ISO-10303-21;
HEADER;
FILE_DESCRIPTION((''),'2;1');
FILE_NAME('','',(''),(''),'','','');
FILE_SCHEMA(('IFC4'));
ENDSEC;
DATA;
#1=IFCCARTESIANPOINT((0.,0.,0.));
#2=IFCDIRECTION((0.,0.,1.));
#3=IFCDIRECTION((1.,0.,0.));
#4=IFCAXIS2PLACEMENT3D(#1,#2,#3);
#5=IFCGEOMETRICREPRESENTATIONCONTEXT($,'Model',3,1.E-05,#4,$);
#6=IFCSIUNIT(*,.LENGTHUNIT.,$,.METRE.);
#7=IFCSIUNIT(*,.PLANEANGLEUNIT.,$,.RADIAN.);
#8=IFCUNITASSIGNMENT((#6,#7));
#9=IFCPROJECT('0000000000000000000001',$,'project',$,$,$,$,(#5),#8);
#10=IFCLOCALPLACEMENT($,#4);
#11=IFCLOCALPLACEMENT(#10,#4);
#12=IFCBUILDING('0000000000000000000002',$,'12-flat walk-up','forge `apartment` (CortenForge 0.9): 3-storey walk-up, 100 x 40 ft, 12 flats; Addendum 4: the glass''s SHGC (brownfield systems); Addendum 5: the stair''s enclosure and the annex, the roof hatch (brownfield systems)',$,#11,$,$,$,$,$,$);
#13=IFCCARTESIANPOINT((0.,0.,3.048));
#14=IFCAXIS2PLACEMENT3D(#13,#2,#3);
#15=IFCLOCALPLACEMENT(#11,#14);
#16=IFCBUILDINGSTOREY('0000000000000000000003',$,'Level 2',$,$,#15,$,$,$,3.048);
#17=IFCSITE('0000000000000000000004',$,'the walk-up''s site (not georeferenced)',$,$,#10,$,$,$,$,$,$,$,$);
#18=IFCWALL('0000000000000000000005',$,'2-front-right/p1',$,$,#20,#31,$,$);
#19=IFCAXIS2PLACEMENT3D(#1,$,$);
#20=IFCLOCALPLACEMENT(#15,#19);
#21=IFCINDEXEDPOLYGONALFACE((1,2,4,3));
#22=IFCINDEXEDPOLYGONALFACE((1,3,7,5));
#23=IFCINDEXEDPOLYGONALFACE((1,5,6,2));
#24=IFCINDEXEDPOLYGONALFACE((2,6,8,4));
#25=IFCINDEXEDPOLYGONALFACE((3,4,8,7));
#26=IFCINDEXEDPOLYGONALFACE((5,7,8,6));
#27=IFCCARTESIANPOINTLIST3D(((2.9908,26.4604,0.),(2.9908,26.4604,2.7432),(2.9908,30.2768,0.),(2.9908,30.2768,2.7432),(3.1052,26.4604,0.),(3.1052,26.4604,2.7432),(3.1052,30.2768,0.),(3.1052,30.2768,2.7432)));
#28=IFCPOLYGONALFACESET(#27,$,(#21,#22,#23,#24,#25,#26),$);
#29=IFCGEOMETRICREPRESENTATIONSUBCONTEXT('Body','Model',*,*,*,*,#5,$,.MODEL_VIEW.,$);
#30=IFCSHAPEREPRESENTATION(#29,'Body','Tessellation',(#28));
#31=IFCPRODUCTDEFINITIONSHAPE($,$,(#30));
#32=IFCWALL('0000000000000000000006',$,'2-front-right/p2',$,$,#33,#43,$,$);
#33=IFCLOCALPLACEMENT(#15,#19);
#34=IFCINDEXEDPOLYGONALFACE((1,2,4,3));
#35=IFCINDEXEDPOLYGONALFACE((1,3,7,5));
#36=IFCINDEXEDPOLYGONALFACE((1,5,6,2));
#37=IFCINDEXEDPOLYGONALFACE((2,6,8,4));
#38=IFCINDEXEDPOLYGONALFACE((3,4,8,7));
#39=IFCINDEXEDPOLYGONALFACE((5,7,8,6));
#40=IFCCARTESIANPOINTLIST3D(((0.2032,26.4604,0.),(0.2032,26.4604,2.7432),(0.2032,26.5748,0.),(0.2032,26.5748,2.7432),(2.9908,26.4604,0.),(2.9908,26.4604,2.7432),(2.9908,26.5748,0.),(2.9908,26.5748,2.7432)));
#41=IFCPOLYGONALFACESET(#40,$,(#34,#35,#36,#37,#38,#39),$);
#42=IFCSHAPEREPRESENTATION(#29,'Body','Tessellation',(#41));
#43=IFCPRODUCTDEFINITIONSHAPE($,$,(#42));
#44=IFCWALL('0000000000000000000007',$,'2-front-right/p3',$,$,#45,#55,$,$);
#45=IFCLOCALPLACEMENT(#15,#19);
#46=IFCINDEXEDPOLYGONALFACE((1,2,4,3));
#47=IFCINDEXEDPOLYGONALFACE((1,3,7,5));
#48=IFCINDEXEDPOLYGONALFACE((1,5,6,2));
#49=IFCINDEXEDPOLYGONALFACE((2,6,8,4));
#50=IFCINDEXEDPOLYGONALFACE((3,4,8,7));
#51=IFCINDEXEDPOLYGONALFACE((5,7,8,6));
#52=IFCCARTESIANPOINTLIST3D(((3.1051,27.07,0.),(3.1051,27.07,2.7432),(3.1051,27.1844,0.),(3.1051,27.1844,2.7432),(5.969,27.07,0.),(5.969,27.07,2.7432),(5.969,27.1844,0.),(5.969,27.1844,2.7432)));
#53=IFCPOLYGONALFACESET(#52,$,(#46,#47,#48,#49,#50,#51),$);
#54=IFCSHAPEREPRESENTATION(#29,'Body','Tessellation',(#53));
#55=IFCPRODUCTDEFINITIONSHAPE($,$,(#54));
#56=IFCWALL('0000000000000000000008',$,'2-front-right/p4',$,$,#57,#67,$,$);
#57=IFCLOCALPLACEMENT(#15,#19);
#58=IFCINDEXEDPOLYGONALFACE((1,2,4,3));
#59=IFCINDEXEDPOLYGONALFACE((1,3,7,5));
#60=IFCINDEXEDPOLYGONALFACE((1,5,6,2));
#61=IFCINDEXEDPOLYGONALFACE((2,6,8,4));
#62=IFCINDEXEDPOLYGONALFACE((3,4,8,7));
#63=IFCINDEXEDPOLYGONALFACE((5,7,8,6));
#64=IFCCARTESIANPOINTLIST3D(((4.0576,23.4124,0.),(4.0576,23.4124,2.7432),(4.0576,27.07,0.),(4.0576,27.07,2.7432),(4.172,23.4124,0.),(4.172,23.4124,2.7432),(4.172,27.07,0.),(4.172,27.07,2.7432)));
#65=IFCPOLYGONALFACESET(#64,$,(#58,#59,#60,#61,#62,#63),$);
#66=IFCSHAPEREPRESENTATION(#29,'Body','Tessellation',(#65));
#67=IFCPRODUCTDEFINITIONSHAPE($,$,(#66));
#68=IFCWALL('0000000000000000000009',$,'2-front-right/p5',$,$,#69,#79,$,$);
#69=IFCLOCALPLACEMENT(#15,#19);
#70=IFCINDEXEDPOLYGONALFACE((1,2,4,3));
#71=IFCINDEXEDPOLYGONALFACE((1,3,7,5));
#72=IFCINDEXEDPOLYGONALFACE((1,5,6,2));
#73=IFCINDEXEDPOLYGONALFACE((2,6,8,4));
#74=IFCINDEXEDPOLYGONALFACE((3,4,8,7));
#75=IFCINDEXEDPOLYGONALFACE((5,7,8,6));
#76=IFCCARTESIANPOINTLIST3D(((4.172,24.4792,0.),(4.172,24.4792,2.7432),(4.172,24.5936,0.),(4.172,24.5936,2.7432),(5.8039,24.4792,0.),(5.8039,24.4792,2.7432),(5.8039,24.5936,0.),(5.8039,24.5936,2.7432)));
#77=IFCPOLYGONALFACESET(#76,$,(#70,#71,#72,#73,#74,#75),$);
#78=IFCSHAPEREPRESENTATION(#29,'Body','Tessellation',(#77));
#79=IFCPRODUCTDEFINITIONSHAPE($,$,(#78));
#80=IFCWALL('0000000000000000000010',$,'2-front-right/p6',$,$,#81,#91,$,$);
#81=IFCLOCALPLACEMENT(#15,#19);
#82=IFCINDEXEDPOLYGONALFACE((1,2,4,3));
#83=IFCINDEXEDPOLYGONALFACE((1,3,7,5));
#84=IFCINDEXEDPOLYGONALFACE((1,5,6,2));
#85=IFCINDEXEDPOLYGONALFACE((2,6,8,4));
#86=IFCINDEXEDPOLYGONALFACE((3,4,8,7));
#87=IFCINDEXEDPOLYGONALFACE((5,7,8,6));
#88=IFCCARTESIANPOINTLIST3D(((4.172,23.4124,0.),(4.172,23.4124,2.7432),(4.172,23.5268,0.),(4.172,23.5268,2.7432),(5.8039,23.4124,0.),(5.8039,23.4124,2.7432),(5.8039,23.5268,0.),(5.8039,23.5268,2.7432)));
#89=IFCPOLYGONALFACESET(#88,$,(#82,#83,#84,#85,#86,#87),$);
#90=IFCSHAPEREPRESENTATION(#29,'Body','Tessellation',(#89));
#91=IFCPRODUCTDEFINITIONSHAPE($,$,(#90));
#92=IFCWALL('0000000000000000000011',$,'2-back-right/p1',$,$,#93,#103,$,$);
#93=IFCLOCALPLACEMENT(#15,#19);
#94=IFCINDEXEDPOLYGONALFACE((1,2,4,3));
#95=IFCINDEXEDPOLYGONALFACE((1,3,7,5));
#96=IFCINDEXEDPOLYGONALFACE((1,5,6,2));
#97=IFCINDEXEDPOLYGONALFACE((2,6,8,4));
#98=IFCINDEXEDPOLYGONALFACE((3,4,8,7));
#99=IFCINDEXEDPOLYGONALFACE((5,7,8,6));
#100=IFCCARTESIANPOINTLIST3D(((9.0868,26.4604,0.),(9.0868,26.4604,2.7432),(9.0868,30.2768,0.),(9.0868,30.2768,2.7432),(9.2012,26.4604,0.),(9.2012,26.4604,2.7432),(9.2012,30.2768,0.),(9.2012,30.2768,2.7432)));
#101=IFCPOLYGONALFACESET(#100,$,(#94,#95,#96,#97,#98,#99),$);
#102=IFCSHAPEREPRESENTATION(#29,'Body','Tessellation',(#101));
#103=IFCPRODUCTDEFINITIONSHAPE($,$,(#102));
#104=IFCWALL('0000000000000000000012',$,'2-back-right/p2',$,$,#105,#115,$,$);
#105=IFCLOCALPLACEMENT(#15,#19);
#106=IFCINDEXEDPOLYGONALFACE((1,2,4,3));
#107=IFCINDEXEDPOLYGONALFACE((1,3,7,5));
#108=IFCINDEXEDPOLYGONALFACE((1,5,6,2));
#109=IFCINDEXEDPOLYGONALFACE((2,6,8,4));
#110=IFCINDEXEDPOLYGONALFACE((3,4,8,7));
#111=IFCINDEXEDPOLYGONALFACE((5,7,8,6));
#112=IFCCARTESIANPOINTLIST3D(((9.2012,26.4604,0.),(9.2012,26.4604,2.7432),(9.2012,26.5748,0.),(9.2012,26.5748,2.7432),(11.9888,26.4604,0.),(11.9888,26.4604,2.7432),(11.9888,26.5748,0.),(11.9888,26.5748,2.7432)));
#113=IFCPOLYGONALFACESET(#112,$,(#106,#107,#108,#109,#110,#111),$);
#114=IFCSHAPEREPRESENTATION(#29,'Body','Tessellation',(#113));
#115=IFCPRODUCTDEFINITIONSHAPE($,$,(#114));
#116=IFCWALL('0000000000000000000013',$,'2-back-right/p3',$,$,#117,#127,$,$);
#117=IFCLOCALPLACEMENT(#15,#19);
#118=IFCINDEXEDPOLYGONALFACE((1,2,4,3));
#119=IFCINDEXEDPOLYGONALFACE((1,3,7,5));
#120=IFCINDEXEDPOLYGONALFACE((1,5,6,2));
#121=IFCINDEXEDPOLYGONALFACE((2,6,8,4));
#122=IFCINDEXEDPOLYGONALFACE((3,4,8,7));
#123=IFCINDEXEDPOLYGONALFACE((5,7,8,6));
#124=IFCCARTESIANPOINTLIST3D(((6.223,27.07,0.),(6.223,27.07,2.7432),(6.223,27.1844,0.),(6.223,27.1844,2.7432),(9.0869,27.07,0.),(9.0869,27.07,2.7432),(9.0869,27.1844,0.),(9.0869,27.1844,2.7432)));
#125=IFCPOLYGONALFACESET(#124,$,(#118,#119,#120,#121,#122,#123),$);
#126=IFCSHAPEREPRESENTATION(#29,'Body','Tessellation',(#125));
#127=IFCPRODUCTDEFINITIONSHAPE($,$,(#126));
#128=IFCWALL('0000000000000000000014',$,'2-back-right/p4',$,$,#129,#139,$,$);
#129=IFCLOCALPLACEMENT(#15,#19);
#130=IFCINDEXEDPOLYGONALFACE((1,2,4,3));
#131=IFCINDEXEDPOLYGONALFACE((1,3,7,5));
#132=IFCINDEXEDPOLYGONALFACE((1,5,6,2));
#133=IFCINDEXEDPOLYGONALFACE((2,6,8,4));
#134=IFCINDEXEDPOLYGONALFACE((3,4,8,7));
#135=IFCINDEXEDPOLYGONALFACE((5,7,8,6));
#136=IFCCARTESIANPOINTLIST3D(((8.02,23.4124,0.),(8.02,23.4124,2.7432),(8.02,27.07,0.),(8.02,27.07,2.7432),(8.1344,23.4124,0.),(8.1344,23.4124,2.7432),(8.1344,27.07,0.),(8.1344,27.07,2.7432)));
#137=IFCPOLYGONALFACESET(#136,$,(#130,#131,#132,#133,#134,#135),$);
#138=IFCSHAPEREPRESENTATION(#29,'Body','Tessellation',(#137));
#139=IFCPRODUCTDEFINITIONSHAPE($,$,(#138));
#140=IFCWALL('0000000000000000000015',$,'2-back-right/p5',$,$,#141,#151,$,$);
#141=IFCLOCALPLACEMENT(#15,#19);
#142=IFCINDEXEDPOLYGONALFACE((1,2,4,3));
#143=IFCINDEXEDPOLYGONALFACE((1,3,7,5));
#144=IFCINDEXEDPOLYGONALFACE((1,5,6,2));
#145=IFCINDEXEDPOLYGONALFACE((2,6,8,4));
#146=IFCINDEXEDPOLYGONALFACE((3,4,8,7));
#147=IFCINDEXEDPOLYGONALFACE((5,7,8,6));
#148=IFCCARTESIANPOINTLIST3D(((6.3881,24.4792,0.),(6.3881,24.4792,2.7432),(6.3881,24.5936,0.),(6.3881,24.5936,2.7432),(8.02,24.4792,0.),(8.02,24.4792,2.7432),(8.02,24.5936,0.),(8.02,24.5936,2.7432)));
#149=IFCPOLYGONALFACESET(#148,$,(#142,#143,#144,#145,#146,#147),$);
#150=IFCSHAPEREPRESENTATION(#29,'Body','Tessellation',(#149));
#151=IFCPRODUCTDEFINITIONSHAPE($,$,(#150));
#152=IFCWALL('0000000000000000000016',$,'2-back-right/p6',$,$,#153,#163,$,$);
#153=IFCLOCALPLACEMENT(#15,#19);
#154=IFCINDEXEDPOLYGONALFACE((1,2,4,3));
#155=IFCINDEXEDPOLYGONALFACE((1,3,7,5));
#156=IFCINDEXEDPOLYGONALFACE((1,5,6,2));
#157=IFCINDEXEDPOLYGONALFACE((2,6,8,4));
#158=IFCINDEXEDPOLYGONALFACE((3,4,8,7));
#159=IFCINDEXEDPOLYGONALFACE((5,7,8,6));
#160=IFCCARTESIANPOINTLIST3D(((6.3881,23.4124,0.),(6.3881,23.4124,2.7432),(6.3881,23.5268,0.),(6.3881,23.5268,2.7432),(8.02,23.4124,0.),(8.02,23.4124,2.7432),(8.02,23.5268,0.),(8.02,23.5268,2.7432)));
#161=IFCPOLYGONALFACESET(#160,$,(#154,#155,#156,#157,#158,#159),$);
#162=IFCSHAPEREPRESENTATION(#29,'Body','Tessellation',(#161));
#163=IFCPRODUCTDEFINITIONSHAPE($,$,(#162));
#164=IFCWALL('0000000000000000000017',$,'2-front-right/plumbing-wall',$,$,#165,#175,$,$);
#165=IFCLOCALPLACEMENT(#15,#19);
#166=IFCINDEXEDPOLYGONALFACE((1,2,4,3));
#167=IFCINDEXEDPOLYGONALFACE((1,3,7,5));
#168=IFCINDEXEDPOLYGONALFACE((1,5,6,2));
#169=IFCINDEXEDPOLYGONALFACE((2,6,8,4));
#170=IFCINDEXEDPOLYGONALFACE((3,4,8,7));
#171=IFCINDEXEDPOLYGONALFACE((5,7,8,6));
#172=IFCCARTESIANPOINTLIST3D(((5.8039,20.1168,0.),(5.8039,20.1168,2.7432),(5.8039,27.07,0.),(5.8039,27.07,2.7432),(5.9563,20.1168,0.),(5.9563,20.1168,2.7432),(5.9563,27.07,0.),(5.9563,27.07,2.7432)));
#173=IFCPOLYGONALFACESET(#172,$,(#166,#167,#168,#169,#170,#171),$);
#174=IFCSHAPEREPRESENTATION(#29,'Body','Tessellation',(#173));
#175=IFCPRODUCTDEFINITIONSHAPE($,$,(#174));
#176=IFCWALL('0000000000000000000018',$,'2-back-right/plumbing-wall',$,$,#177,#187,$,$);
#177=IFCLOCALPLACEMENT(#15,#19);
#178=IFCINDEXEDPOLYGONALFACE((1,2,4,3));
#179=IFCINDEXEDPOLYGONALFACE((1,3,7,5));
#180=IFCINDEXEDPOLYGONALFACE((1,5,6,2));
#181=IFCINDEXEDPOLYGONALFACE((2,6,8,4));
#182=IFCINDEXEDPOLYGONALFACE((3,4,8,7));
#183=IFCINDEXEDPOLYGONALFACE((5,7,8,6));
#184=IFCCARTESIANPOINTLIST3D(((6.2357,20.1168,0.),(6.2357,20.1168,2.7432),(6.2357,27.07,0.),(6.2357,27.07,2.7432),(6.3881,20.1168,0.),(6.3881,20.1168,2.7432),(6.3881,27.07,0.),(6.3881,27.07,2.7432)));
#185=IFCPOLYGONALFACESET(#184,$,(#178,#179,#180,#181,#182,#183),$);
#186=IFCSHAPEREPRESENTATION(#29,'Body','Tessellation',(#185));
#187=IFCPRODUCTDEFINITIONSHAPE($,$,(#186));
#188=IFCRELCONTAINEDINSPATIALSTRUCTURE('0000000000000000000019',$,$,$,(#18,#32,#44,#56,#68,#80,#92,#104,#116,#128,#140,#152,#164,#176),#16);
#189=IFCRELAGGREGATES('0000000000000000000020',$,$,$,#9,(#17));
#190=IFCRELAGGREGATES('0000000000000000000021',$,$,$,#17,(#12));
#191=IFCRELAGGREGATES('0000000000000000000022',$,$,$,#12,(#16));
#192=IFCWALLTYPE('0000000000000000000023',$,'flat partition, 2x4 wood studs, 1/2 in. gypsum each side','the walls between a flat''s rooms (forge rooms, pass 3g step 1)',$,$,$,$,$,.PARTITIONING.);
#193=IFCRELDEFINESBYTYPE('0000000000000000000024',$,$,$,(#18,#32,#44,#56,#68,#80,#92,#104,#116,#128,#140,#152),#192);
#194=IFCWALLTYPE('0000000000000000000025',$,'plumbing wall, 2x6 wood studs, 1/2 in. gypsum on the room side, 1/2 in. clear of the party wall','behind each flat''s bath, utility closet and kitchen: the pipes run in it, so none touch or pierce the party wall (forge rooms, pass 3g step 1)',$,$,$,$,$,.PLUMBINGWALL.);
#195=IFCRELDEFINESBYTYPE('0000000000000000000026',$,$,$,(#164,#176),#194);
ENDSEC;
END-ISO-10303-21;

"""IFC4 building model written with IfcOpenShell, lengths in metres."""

from ifc_helpers import new_model, si_unit, frame, frame_2d, origin, origin_with_axes, place, context, subcontext, project, spatial, rectangle, extrude, type_object, element, save


model = new_model("IFC4")

# Units and contexts
model_context = context("Model", 3, precision=1e-05, world=origin_with_axes())
body_context = subcontext(model_context, "Body", "Model", "MODEL_VIEW")
ifc_project = project(units=[si_unit("LENGTHUNIT", "METRE"), si_unit("PLANEANGLEUNIT", "RADIAN")], contexts=[model_context])

# Site, building, storey
site_placement = place(None, origin_with_axes())
site = spatial("IfcSite", under=ifc_project, at=site_placement, Name="the walk-up's site (not georeferenced)")
building_placement = place(site_placement, origin_with_axes())
building = spatial("IfcBuilding", under=site, at=building_placement, Name="12-flat walk-up", Description="forge `apartment` (CortenForge 0.9): 3-storey walk-up, 100 x 40 ft, 12 flats; Addendum 4: the glass's SHGC (brownfield systems); Addendum 5: the stair's enclosure and the annex, the roof hatch (brownfield systems)")
storey_placement = place(building_placement, frame((0.0, 0.0, 3.048), z_axis=(0.0, 0.0, 1.0), x_axis=(1.0, 0.0, 0.0)))
storey = spatial("IfcBuildingStorey", under=building, at=storey_placement, Name="Level 2", Elevation=3.048)

# Walls
wall_type_1 = type_object("IfcWallType", Name="flat partition, 2x4 wood studs, 1/2 in. gypsum each side", Description="the walls between a flat's rooms (forge rooms, pass 3g step 1)", PredefinedType="PARTITIONING")
wall_1_placement = place(storey_placement, frame((2.9909, 26.4605, 0.0), z_axis=(0.0, 0.0, 1.0), x_axis=(1.0, 0.0, 0.0)))
element("IfcWall", 1, at=wall_1_placement, inside=storey, type_object=wall_type_1, Name="2-front-right/p1", context=body_context, shape_type="SweptSolid", body=[
    extrude(rectangle(XDim=0.1143, YDim=3.8163, at=frame_2d((0.0572, 1.9082))), origin(), (0.0, 0.0, 1.0), 2.7432),
])
wall_2_placement = place(storey_placement, frame((0.2032, 26.4605, 0.0), z_axis=(0.0, 0.0, 1.0), x_axis=(1.0, 0.0, 0.0)))
element("IfcWall", 2, at=wall_2_placement, inside=storey, type_object=wall_type_1, Name="2-front-right/p2", context=body_context, shape_type="SweptSolid", body=[
    extrude(rectangle(XDim=2.7877, YDim=0.1143, at=frame_2d((1.3938, 0.0572))), origin(), (0.0, 0.0, 1.0), 2.7432),
])
wall_3_placement = place(storey_placement, frame((3.1051, 27.07, 0.0), z_axis=(0.0, 0.0, 1.0), x_axis=(1.0, 0.0, 0.0)))
element("IfcWall", 3, at=wall_3_placement, inside=storey, type_object=wall_type_1, Name="2-front-right/p3", context=body_context, shape_type="SweptSolid", body=[
    extrude(rectangle(XDim=2.8639, YDim=0.1143, at=frame_2d((1.4319, 0.0572))), origin(), (0.0, 0.0, 1.0), 2.7432),
])
wall_4_placement = place(storey_placement, frame((4.0576, 23.4124, 0.0), z_axis=(0.0, 0.0, 1.0), x_axis=(1.0, 0.0, 0.0)))
element("IfcWall", 4, at=wall_4_placement, inside=storey, type_object=wall_type_1, Name="2-front-right/p4", context=body_context, shape_type="SweptSolid", body=[
    extrude(rectangle(XDim=0.1143, YDim=3.6576, at=frame_2d((0.0572, 1.8288))), origin(), (0.0, 0.0, 1.0), 2.7432),
])
for number, where, z_axis, x_axis, name in (
    (5, (4.1719, 24.4793, 0.0), (0.0, 0.0, 1.0), (1.0, 0.0, 0.0), "2-front-right/p5"),
    (6, (4.1719, 23.4124, 0.0), (0.0, 0.0, 1.0), (1.0, 0.0, 0.0), "2-front-right/p6"),
):
    element("IfcWall", number, at=place(storey_placement, frame(where, z_axis=z_axis, x_axis=x_axis)), inside=storey, type_object=wall_type_1, Name=name, context=body_context, shape_type="SweptSolid", body=[
        extrude(rectangle(XDim=1.6319, YDim=0.1143, at=frame_2d((0.816, 0.0572))), origin(), (0.0, 0.0, 1.0), 2.7432),
    ])
wall_5_placement = place(storey_placement, frame((9.0869, 26.4605, 0.0), z_axis=(0.0, 0.0, 1.0), x_axis=(1.0, 0.0, 0.0)))
element("IfcWall", 7, at=wall_5_placement, inside=storey, type_object=wall_type_1, Name="2-back-right/p1", context=body_context, shape_type="SweptSolid", body=[
    extrude(rectangle(XDim=0.1143, YDim=3.8163, at=frame_2d((0.0572, 1.9082))), origin(), (0.0, 0.0, 1.0), 2.7432),
])
wall_6_placement = place(storey_placement, frame((9.2012, 26.4605, 0.0), z_axis=(0.0, 0.0, 1.0), x_axis=(1.0, 0.0, 0.0)))
element("IfcWall", 8, at=wall_6_placement, inside=storey, type_object=wall_type_1, Name="2-back-right/p2", context=body_context, shape_type="SweptSolid", body=[
    extrude(rectangle(XDim=2.7876, YDim=0.1143, at=frame_2d((1.3938, 0.0572))), origin(), (0.0, 0.0, 1.0), 2.7432),
])
wall_7_placement = place(storey_placement, frame((6.223, 27.07, 0.0), z_axis=(0.0, 0.0, 1.0), x_axis=(1.0, 0.0, 0.0)))
element("IfcWall", 9, at=wall_7_placement, inside=storey, type_object=wall_type_1, Name="2-back-right/p3", context=body_context, shape_type="SweptSolid", body=[
    extrude(rectangle(XDim=2.8639, YDim=0.1143, at=frame_2d((1.4319, 0.0572))), origin(), (0.0, 0.0, 1.0), 2.7432),
])
wall_8_placement = place(storey_placement, frame((8.02, 23.4124, 0.0), z_axis=(0.0, 0.0, 1.0), x_axis=(1.0, 0.0, 0.0)))
element("IfcWall", 10, at=wall_8_placement, inside=storey, type_object=wall_type_1, Name="2-back-right/p4", context=body_context, shape_type="SweptSolid", body=[
    extrude(rectangle(XDim=0.1143, YDim=3.6576, at=frame_2d((0.0572, 1.8288))), origin(), (0.0, 0.0, 1.0), 2.7432),
])
for number, where, z_axis, x_axis, name in (
    (11, (6.3881, 24.4793, 0.0), (0.0, 0.0, 1.0), (1.0, 0.0, 0.0), "2-back-right/p5"),
    (12, (6.3881, 23.4124, 0.0), (0.0, 0.0, 1.0), (1.0, 0.0, 0.0), "2-back-right/p6"),
):
    element("IfcWall", number, at=place(storey_placement, frame(where, z_axis=z_axis, x_axis=x_axis)), inside=storey, type_object=wall_type_1, Name=name, context=body_context, shape_type="SweptSolid", body=[
        extrude(rectangle(XDim=1.6319, YDim=0.1143, at=frame_2d((0.816, 0.0572))), origin(), (0.0, 0.0, 1.0), 2.7432),
    ])
wall_type_2 = type_object("IfcWallType", Name="plumbing wall, 2x6 wood studs, 1/2 in. gypsum on the room side, 1/2 in. clear of the party wall", Description="behind each flat's bath, utility closet and kitchen: the pipes run in it, so none touch or pierce the party wall (forge rooms, pass 3g step 1)", PredefinedType="PLUMBINGWALL")
for number, where, z_axis, x_axis, name in (
    (13, (5.8039, 20.1168, 0.0), (0.0, 0.0, 1.0), (1.0, 0.0, 0.0), "2-front-right/plumbing-wall"),
    (14, (6.2357, 20.1168, 0.0), (0.0, 0.0, 1.0), (1.0, 0.0, 0.0), "2-back-right/plumbing-wall"),
):
    element("IfcWall", number, at=place(storey_placement, frame(where, z_axis=z_axis, x_axis=x_axis)), inside=storey, type_object=wall_type_2, Name=name, context=body_context, shape_type="SweptSolid", body=[
        extrude(rectangle(XDim=0.1524, YDim=6.9532, at=frame_2d((0.0762, 3.4766))), origin(), (0.0, 0.0, 1.0), 2.7432),
    ])

save(model, "model.ifc")
